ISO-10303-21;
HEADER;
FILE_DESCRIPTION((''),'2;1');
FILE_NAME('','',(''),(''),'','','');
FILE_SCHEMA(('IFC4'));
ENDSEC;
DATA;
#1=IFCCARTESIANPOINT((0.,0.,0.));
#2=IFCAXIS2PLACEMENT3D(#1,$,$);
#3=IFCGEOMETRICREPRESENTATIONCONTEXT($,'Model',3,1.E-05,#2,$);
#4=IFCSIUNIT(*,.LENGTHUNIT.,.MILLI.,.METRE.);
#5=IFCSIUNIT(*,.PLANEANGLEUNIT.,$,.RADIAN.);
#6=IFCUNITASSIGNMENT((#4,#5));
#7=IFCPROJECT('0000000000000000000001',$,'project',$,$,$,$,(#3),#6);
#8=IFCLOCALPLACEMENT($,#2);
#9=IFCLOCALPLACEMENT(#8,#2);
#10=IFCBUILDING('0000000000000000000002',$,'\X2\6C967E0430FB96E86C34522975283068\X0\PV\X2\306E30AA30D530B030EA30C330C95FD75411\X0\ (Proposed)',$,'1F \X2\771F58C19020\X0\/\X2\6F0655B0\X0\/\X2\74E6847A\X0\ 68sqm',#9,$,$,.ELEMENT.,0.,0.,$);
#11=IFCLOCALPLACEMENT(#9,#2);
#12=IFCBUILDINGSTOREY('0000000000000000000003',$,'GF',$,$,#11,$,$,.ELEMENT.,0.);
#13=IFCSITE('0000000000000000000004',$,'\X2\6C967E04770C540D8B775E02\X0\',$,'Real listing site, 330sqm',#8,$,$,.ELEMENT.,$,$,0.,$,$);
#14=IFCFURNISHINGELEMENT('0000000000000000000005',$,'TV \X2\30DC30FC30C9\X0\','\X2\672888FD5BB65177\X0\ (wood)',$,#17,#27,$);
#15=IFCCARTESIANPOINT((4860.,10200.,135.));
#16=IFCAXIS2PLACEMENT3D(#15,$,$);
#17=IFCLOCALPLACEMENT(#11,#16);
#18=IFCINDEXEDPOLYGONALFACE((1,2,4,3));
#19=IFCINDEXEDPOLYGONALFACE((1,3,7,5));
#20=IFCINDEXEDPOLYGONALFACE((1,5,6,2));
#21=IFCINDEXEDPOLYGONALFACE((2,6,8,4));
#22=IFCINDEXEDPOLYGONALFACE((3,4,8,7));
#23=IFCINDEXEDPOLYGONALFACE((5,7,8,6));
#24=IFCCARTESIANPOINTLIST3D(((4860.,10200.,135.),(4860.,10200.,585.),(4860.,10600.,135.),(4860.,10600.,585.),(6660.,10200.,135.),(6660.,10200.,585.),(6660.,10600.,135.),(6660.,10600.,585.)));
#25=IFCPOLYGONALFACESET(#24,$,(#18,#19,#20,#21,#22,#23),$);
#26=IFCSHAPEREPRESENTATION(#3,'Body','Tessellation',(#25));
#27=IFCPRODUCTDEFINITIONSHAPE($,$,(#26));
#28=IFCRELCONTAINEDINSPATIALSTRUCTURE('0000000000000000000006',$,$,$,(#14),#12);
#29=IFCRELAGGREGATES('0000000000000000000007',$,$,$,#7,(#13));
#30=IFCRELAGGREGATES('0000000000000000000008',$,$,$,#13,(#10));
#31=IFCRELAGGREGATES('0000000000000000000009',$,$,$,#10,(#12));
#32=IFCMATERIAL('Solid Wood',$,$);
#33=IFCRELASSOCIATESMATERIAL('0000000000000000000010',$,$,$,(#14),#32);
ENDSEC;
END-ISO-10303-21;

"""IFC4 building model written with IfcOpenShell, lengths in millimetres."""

from ifc_helpers import new_model, si_unit, frame, frame_2d, origin, place, context, project, spatial, rectangle, extrude, material, element, save


model = new_model("IFC4")

# Units and contexts
model_context = context("Model", 3, precision=1e-05, world=origin())
ifc_project = project(units=[si_unit("LENGTHUNIT", "METRE", prefix="MILLI"), si_unit("PLANEANGLEUNIT", "RADIAN")], contexts=[model_context])

# Site, building, storey
site_placement = place(None, origin())
site = spatial("IfcSite", under=ifc_project, at=site_placement, Name="沖縄県名護市", ObjectType="Real listing site, 330sqm", CompositionType="ELEMENT", RefElevation=0.0)
building_placement = place(site_placement, origin())
building = spatial("IfcBuilding", under=site, at=building_placement, Name="沖縄・雨水利用とPVのオフグリッド志向 (Proposed)", ObjectType="1F 真壁造/漆喰/瓦葺 68sqm", CompositionType="ELEMENT", ElevationOfRefHeight=0.0, ElevationOfTerrain=0.0)
storey_placement = place(building_placement, origin())
storey = spatial("IfcBuildingStorey", under=building, at=storey_placement, Name="GF", CompositionType="ELEMENT", Elevation=0.0)

# Shared definitions
ifc_material_1 = material(Name="Solid Wood")

# Furnishing element
furnishing_placement = place(storey_placement, frame((4860.0, 10200.0, 135.0)))
element("IfcFurnishingElement", 1, at=furnishing_placement, inside=storey, material=ifc_material_1, Name="TV ボード", Description="木製家具 (wood)", context=model_context, shape_type="SweptSolid", body=[
    extrude(rectangle(XDim=1800.0, YDim=400.0, at=frame_2d((900.0, 200.0))), frame((4860.0, 10200.0, 135.0)), (0.0, 0.0, 1.0), 450.0),
])

save(model, "model.ifc")
